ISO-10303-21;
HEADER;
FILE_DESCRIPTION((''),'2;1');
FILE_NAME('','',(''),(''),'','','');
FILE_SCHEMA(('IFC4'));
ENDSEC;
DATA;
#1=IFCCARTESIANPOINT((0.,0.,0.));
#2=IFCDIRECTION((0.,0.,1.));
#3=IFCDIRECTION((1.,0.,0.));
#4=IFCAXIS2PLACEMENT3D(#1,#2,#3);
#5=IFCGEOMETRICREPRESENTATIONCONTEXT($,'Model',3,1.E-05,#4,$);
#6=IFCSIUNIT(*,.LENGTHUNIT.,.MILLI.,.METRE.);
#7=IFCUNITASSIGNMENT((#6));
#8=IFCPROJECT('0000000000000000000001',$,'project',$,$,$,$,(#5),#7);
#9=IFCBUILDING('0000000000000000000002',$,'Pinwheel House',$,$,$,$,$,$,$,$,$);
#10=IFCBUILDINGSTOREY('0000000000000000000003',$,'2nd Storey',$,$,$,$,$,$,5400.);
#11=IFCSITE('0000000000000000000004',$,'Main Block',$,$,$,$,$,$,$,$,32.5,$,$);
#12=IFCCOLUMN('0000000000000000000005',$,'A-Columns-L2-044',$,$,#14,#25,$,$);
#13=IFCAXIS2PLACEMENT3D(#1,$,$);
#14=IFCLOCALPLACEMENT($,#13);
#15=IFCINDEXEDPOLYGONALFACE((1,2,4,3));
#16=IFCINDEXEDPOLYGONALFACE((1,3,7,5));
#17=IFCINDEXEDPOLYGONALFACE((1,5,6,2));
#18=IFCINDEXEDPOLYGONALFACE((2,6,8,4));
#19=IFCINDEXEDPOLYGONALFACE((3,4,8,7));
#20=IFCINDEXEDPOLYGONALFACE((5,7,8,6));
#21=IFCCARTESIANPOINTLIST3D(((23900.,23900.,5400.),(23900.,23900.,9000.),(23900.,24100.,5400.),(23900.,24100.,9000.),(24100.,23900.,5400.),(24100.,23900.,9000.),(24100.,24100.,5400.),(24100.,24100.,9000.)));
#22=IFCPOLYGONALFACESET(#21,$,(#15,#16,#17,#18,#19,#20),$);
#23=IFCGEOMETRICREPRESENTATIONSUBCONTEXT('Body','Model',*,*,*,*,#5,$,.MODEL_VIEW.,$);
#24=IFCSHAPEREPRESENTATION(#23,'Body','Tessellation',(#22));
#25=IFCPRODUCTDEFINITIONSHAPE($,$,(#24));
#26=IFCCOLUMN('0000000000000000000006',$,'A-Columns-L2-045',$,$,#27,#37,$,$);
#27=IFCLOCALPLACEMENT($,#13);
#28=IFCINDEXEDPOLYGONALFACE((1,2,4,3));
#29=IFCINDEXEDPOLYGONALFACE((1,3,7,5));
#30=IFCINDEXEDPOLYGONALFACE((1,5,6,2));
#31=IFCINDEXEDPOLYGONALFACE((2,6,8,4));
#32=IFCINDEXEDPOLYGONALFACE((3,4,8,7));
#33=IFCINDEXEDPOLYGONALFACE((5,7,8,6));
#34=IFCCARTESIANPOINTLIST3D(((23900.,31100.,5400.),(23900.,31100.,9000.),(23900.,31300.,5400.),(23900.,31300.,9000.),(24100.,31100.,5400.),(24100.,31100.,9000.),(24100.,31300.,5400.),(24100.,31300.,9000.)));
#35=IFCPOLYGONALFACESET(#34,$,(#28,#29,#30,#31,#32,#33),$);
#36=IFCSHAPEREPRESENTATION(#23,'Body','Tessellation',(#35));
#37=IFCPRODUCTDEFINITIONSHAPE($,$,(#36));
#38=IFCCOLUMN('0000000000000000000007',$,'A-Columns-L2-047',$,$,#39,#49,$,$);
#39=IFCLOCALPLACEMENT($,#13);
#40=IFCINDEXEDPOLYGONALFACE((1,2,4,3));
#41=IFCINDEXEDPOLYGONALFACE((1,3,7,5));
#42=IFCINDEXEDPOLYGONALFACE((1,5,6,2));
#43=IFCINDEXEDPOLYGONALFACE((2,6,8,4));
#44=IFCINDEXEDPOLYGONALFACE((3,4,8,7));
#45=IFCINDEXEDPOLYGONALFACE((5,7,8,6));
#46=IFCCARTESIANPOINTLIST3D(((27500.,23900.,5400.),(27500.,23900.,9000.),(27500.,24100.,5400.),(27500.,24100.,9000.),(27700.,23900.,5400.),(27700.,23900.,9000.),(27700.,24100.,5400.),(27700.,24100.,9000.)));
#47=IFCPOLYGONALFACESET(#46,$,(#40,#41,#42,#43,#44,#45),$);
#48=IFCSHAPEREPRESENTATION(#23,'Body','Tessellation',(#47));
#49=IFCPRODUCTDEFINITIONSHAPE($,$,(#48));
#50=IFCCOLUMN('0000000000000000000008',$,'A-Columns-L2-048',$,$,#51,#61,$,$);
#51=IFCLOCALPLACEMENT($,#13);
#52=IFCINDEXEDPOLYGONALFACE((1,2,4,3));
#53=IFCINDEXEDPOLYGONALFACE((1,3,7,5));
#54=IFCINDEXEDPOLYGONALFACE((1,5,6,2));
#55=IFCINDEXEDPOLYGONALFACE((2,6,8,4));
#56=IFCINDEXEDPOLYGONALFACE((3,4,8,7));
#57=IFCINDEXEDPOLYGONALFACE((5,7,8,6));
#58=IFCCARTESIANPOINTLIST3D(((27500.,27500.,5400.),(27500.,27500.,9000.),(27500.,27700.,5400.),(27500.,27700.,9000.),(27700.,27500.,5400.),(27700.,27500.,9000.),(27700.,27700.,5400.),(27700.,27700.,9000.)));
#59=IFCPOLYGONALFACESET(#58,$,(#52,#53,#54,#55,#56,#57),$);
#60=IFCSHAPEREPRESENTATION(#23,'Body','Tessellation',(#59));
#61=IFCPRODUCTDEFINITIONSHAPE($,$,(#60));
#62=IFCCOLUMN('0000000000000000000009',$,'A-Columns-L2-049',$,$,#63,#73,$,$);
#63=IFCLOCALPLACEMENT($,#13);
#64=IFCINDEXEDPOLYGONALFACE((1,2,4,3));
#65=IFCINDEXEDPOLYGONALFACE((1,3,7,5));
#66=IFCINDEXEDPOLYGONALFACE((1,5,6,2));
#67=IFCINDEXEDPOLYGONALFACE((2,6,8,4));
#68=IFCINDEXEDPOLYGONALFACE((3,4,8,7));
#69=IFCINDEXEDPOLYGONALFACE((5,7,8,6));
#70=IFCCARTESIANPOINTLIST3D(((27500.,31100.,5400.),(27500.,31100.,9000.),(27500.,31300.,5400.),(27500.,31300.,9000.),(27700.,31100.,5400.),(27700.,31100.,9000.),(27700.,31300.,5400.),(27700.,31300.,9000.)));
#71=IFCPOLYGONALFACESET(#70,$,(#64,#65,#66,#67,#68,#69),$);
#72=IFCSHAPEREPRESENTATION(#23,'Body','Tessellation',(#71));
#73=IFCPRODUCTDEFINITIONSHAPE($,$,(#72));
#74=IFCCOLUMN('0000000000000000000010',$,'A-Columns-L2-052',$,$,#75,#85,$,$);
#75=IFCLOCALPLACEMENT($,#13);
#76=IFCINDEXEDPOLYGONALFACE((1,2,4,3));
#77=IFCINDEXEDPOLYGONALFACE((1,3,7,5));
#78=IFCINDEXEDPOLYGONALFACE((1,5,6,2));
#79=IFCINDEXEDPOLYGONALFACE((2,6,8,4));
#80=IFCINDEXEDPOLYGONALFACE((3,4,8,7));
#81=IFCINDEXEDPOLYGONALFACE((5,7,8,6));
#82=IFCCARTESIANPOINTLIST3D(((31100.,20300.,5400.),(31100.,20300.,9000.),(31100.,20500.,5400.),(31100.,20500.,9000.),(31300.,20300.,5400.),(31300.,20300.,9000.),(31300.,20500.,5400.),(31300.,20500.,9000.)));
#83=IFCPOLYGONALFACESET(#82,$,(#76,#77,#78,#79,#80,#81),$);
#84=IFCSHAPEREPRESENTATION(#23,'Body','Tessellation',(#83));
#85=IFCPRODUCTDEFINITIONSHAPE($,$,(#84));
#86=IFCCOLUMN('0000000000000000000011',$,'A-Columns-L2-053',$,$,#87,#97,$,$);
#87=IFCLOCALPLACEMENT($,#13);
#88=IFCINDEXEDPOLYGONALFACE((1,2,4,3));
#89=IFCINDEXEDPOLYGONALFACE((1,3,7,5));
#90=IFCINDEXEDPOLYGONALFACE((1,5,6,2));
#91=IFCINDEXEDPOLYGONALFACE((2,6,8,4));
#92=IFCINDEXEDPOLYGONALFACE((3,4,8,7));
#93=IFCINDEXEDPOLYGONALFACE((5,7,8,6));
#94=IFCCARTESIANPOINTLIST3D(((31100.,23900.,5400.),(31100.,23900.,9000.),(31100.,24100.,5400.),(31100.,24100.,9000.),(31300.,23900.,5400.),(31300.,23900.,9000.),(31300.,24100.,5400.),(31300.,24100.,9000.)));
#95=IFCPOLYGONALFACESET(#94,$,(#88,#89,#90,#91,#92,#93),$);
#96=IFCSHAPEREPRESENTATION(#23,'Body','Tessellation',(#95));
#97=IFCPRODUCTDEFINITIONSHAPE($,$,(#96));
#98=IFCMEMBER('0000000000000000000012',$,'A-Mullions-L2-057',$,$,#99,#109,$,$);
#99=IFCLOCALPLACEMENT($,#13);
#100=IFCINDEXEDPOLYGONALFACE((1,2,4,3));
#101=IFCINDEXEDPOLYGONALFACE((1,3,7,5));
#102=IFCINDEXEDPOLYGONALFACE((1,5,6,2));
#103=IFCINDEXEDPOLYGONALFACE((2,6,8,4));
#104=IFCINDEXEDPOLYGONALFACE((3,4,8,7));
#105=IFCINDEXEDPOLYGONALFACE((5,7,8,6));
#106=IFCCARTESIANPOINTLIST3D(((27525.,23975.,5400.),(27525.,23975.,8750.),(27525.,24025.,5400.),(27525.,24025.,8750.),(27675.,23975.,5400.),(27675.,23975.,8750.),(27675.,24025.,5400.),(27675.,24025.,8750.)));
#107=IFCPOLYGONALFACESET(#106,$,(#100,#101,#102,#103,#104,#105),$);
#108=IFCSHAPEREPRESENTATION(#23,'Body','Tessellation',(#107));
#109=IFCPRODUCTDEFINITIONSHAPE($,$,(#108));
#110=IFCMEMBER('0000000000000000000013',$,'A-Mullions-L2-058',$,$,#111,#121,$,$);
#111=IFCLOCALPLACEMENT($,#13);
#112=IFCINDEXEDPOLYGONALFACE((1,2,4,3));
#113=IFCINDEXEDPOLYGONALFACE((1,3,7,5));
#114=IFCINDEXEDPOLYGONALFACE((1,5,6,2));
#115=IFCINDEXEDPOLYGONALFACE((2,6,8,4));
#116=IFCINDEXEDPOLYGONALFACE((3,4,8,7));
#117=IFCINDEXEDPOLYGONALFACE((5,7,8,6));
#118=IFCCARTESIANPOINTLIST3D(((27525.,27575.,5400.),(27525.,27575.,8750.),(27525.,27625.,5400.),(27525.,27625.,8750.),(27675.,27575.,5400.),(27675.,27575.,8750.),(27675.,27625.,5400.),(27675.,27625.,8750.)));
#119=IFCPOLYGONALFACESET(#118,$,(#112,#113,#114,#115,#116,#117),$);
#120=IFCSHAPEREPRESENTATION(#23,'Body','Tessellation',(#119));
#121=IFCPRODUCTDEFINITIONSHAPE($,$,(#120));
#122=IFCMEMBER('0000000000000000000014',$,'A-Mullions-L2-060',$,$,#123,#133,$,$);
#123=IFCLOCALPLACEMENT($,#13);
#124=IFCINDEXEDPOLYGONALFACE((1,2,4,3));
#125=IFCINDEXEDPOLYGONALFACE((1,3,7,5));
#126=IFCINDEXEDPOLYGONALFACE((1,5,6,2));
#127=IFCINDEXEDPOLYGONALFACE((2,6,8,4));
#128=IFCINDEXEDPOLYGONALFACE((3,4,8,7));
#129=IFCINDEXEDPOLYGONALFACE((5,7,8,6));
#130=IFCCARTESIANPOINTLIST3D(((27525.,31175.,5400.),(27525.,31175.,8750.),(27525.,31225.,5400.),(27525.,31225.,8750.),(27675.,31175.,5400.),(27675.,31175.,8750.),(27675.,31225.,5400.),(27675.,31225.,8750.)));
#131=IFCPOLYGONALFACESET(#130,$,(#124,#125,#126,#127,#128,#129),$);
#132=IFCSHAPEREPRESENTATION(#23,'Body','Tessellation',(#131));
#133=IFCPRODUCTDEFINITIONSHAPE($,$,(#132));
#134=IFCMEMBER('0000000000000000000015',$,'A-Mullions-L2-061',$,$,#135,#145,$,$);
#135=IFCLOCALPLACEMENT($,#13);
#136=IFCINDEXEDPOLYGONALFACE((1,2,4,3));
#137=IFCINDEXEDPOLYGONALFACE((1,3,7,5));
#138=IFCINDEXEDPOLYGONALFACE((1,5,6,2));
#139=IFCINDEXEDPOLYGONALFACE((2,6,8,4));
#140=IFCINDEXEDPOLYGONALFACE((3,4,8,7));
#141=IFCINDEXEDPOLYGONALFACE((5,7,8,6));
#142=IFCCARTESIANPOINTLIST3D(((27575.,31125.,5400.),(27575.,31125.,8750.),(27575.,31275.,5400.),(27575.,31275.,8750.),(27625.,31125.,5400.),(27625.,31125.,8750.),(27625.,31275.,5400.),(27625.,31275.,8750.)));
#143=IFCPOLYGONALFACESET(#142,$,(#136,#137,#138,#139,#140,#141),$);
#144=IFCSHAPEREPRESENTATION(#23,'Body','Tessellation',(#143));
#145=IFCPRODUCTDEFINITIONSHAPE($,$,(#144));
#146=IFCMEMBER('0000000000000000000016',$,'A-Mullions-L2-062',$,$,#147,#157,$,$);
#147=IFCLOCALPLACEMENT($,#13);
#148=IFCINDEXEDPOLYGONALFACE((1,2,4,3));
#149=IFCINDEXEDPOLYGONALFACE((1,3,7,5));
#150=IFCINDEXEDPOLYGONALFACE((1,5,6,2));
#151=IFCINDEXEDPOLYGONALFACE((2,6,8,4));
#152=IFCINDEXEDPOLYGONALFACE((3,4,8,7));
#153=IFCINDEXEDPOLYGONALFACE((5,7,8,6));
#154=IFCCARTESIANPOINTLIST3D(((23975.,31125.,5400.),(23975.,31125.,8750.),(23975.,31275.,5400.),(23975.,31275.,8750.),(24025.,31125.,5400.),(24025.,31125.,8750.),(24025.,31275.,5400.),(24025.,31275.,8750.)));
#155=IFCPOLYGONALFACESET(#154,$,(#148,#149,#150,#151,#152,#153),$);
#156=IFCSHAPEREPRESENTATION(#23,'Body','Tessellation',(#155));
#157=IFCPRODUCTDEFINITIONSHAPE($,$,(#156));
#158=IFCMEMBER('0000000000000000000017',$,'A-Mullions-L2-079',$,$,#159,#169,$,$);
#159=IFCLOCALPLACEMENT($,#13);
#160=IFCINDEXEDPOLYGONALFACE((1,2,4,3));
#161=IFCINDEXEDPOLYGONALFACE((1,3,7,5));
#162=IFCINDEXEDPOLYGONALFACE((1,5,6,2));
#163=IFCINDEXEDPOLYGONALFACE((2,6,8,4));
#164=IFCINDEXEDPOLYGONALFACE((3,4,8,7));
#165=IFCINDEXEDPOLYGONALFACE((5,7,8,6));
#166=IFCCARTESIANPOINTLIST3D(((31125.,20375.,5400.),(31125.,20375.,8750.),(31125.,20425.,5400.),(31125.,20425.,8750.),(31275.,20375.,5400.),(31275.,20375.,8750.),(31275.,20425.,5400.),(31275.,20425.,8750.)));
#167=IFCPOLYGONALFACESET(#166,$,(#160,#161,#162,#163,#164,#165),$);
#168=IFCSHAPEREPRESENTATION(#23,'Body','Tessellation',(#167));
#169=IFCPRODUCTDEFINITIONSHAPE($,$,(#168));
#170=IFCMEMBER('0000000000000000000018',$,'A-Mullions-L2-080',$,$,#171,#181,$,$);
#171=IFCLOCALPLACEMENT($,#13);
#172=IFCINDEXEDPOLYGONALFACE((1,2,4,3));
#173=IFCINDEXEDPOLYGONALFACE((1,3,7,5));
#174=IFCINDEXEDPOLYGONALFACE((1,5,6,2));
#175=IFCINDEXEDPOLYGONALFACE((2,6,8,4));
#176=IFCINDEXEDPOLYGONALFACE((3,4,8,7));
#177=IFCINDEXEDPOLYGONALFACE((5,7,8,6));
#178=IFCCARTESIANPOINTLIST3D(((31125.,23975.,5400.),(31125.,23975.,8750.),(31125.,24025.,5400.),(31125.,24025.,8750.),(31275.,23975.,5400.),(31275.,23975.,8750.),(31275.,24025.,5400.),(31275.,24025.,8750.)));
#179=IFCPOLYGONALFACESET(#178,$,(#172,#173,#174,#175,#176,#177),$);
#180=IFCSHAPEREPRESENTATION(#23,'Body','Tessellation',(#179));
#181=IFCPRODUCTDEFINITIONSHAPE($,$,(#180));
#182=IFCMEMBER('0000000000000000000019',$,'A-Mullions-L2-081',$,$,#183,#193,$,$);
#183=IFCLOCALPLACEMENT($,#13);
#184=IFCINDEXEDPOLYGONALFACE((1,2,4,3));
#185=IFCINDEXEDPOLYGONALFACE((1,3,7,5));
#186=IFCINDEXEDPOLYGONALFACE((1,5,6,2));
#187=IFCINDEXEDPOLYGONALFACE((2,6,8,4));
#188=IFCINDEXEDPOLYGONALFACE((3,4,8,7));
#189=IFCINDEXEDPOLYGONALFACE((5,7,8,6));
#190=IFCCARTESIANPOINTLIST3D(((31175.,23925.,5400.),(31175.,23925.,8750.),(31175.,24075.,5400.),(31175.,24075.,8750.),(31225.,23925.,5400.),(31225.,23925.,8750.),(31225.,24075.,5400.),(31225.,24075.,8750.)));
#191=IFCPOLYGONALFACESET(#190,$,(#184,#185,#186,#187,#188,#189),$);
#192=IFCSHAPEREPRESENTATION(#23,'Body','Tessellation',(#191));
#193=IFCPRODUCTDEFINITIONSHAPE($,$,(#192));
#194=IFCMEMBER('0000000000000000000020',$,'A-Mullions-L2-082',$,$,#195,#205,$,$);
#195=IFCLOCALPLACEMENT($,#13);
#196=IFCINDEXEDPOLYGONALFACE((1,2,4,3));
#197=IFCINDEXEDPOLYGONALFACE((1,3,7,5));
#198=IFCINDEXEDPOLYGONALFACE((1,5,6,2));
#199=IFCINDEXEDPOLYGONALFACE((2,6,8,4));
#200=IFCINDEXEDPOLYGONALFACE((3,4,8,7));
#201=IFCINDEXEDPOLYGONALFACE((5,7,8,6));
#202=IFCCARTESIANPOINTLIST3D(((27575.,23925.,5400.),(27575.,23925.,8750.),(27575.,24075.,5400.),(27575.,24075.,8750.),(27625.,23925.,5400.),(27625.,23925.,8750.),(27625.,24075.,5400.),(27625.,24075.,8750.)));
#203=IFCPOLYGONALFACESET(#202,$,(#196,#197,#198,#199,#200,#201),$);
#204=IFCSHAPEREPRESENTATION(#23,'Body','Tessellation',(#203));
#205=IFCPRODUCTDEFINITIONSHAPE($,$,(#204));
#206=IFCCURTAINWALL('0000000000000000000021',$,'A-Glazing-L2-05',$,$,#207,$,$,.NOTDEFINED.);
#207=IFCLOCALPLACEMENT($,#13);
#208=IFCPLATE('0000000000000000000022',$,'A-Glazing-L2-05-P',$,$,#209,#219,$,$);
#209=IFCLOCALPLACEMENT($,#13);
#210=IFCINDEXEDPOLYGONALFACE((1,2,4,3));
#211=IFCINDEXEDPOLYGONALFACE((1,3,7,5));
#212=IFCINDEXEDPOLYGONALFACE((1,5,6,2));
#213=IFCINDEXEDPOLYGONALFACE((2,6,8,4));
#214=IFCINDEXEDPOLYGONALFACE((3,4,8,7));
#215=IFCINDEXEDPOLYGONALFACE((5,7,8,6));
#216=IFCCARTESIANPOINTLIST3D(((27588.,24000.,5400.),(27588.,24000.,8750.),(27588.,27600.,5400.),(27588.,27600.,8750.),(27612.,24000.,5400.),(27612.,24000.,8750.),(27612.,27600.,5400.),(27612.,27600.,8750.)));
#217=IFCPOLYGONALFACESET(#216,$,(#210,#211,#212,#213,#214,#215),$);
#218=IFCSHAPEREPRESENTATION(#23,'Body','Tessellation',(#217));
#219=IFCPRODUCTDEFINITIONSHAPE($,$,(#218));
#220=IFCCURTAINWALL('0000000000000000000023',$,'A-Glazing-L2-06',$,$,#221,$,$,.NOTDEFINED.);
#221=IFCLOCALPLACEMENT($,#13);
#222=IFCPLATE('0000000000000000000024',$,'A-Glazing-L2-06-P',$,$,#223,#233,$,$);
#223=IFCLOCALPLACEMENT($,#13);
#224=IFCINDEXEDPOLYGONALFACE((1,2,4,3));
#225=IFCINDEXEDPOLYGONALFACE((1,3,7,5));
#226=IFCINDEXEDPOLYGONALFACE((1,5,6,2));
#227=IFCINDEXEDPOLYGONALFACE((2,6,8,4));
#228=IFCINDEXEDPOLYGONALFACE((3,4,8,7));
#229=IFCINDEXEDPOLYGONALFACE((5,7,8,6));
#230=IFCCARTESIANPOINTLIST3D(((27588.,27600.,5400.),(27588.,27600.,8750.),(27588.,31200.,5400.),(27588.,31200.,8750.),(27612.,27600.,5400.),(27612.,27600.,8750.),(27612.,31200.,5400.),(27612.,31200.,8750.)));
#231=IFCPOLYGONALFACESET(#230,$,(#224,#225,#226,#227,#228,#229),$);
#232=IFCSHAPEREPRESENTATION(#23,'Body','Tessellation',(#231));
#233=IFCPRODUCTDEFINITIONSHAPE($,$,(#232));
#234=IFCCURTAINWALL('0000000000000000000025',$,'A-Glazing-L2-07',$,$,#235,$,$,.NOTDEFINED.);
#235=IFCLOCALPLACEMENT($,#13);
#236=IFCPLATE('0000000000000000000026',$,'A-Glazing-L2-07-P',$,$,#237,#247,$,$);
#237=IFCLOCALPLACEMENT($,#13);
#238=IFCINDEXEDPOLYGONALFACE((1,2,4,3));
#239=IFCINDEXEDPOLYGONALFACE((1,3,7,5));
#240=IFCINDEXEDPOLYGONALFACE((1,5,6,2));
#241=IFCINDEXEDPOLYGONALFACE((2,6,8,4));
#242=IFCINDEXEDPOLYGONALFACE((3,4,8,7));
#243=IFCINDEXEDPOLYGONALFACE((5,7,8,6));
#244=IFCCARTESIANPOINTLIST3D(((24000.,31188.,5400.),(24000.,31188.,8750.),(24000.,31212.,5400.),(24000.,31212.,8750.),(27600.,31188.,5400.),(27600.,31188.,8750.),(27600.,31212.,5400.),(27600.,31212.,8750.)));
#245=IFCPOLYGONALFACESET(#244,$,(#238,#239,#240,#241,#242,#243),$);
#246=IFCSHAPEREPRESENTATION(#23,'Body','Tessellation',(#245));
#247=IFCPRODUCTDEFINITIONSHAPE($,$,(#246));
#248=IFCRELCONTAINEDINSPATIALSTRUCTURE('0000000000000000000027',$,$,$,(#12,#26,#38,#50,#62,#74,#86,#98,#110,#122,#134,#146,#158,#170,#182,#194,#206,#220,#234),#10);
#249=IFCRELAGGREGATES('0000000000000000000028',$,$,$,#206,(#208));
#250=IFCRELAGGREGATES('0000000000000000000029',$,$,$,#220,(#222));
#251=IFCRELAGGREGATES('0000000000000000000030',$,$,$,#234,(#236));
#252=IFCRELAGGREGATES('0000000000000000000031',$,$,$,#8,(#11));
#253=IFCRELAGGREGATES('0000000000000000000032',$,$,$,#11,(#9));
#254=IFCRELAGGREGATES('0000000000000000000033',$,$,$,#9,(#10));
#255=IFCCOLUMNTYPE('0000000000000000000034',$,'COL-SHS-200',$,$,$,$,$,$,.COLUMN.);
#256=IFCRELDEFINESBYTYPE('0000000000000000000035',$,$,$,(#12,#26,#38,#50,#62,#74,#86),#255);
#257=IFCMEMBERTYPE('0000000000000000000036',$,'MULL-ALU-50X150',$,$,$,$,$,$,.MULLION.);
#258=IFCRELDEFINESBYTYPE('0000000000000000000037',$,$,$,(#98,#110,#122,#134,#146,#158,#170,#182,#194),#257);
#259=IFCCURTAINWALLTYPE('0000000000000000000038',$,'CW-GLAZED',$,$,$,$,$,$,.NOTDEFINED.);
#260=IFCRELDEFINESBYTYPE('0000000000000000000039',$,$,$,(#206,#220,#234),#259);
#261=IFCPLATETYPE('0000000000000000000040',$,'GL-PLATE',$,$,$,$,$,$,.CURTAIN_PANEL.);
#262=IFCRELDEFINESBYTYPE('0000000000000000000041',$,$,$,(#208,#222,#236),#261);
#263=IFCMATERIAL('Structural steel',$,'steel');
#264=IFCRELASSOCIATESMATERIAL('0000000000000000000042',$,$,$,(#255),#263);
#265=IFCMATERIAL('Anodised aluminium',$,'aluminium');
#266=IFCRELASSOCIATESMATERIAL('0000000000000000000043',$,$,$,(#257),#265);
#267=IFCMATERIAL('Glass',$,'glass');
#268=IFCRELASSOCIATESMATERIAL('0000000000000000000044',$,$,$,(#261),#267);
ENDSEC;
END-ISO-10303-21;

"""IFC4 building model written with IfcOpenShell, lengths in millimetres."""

from ifc_helpers import new_model, si_unit, frame, origin_with_axes, place, context, subcontext, project, spatial, indexed_curve, outline, extrude, material, type_object, element, aggregate, save


model = new_model("IFC4")

# Units and contexts
model_context = context("Model", 3, precision=1e-05, world=origin_with_axes())
body_context = subcontext(model_context, "Body", "Model", "MODEL_VIEW")
ifc_project = project(units=[si_unit("LENGTHUNIT", "METRE", prefix="MILLI")], contexts=[model_context])

# Site, building, storey
site = spatial("IfcSite", under=ifc_project, Name="Main Block", RefElevation=32.5)
building = spatial("IfcBuilding", under=site, Name="Pinwheel House")
storey = spatial("IfcBuildingStorey", under=building, Name="2nd Storey", Elevation=5400.0)

# Columns
ifc_material_1 = material(Name="Structural steel", Category="steel")
column_type = type_object("IfcColumnType", Name="COL-SHS-200", PredefinedType="COLUMN", material=ifc_material_1)
for number, where, z_axis, x_axis, name in (
    (1, (24000.0, 24000.0, 5400.0), (0.0, 0.0, 1.0), (1.0, 0.0, 0.0), "A-Columns-L2-044"),
    (2, (24000.0, 31200.0, 5400.0), (0.0, 0.0, 1.0), (1.0, 0.0, 0.0), "A-Columns-L2-045"),
    (3, (27600.0, 24000.0, 5400.0), (0.0, 0.0, 1.0), (1.0, 0.0, 0.0), "A-Columns-L2-047"),
    (4, (27600.0, 27600.0, 5400.0), (0.0, 0.0, 1.0), (1.0, 0.0, 0.0), "A-Columns-L2-048"),
    (5, (27600.0, 31200.0, 5400.0), (0.0, 0.0, 1.0), (1.0, 0.0, 0.0), "A-Columns-L2-049"),
    (6, (31200.0, 20400.0, 5400.0), (0.0, 0.0, 1.0), (1.0, 0.0, 0.0), "A-Columns-L2-052"),
    (7, (31200.0, 24000.0, 5400.0), (0.0, 0.0, 1.0), (1.0, 0.0, 0.0), "A-Columns-L2-053"),
):
    element("IfcColumn", number, at=place(None, frame(where, z_axis=z_axis, x_axis=x_axis)), inside=storey, type_object=column_type, Name=name, context=body_context, shape_type="SweptSolid", body=[
        extrude(outline(indexed_curve([(-100.0, -100.0), (100.0, -100.0), (100.0, 100.0), (-100.0, 100.0)])), None, (0.0, 0.0, 1.0), 3600.0),
    ])

# Members
ifc_material_2 = material(Name="Anodised aluminium", Category="aluminium")
member_type = type_object("IfcMemberType", Name="MULL-ALU-50X150", PredefinedType="MULLION", material=ifc_material_2)
for number, where, z_axis, x_axis, name in (
    (8, (27600.0, 24000.0, 5400.0), (0.0, 0.0, 1.0), (0.0, 1.0, 0.0), "A-Mullions-L2-057"),
    (9, (27600.0, 27600.0, 5400.0), (0.0, 0.0, 1.0), (0.0, 1.0, 0.0), "A-Mullions-L2-058"),
    (10, (27600.0, 31200.0, 5400.0), (0.0, 0.0, 1.0), (0.0, 1.0, 0.0), "A-Mullions-L2-060"),
    (11, (27600.0, 31200.0, 5400.0), (0.0, 0.0, 1.0), (-1.0, 0.0, 0.0), "A-Mullions-L2-061"),
    (12, (24000.0, 31200.0, 5400.0), (0.0, 0.0, 1.0), (-1.0, 0.0, 0.0), "A-Mullions-L2-062"),
    (13, (31200.0, 20400.0, 5400.0), (0.0, 0.0, 1.0), (0.0, 1.0, 0.0), "A-Mullions-L2-079"),
    (14, (31200.0, 24000.0, 5400.0), (0.0, 0.0, 1.0), (0.0, 1.0, 0.0), "A-Mullions-L2-080"),
    (15, (31200.0, 24000.0, 5400.0), (0.0, 0.0, 1.0), (-1.0, 0.0, 0.0), "A-Mullions-L2-081"),
    (16, (27600.0, 24000.0, 5400.0), (0.0, 0.0, 1.0), (-1.0, 0.0, 0.0), "A-Mullions-L2-082"),
):
    element("IfcMember", number, at=place(None, frame(where, z_axis=z_axis, x_axis=x_axis)), inside=storey, type_object=member_type, Name=name, context=body_context, shape_type="SweptSolid", body=[
        extrude(outline(indexed_curve([(-25.0, -75.0), (25.0, -75.0), (25.0, 75.0), (-25.0, 75.0)])), None, (0.0, 0.0, 1.0), 3350.0),
    ])

# Curtain walls, plates
curtain_wall_type = type_object("IfcCurtainWallType", Name="CW-GLAZED", PredefinedType="NOTDEFINED")
curtain_wall_1 = element("IfcCurtainWall", 17, inside=storey, type_object=curtain_wall_type, Name="A-Glazing-L2-05", PredefinedType="NOTDEFINED")
ifc_material_3 = material(Name="Glass", Category="glass")
plate_type = type_object("IfcPlateType", Name="GL-PLATE", PredefinedType="CURTAIN_PANEL", material=ifc_material_3)
plate_1_placement = place(None, frame((27600.0, 25800.0, 5400.0), z_axis=(0.0, 0.0, 1.0), x_axis=(0.0, 1.0, 0.0)))
plate_1 = element("IfcPlate", 18, at=plate_1_placement, type_object=plate_type, Name="A-Glazing-L2-05-P", context=body_context, shape_type="SweptSolid", body=[
    extrude(outline(indexed_curve([(-1800.0, -12.0), (1800.0, -12.0), (1800.0, 12.0), (-1800.0, 12.0)])), None, (0.0, 0.0, 1.0), 3350.0),
])
aggregate(curtain_wall_1, [plate_1])
curtain_wall_2 = element("IfcCurtainWall", 19, inside=storey, type_object=curtain_wall_type, Name="A-Glazing-L2-06", PredefinedType="NOTDEFINED")
plate_2_placement = place(None, frame((27600.0, 29400.0, 5400.0), z_axis=(0.0, 0.0, 1.0), x_axis=(0.0, 1.0, 0.0)))
plate_2 = element("IfcPlate", 20, at=plate_2_placement, type_object=plate_type, Name="A-Glazing-L2-06-P", context=body_context, shape_type="SweptSolid", body=[
    extrude(outline(indexed_curve([(-1800.0, -12.0), (1800.0, -12.0), (1800.0, 12.0), (-1800.0, 12.0)])), None, (0.0, 0.0, 1.0), 3350.0),
])
aggregate(curtain_wall_2, [plate_2])
curtain_wall_3 = element("IfcCurtainWall", 21, inside=storey, type_object=curtain_wall_type, Name="A-Glazing-L2-07", PredefinedType="NOTDEFINED")
plate_3_placement = place(None, frame((25800.0, 31200.0, 5400.0), z_axis=(0.0, 0.0, 1.0), x_axis=(-1.0, 0.0, 0.0)))
plate_3 = element("IfcPlate", 22, at=plate_3_placement, type_object=plate_type, Name="A-Glazing-L2-07-P", context=body_context, shape_type="SweptSolid", body=[
    extrude(outline(indexed_curve([(-1800.0, -12.0), (1800.0, -12.0), (1800.0, 12.0), (-1800.0, 12.0)])), None, (0.0, 0.0, 1.0), 3350.0),
])
aggregate(curtain_wall_3, [plate_3])

save(model, "model.ifc")
